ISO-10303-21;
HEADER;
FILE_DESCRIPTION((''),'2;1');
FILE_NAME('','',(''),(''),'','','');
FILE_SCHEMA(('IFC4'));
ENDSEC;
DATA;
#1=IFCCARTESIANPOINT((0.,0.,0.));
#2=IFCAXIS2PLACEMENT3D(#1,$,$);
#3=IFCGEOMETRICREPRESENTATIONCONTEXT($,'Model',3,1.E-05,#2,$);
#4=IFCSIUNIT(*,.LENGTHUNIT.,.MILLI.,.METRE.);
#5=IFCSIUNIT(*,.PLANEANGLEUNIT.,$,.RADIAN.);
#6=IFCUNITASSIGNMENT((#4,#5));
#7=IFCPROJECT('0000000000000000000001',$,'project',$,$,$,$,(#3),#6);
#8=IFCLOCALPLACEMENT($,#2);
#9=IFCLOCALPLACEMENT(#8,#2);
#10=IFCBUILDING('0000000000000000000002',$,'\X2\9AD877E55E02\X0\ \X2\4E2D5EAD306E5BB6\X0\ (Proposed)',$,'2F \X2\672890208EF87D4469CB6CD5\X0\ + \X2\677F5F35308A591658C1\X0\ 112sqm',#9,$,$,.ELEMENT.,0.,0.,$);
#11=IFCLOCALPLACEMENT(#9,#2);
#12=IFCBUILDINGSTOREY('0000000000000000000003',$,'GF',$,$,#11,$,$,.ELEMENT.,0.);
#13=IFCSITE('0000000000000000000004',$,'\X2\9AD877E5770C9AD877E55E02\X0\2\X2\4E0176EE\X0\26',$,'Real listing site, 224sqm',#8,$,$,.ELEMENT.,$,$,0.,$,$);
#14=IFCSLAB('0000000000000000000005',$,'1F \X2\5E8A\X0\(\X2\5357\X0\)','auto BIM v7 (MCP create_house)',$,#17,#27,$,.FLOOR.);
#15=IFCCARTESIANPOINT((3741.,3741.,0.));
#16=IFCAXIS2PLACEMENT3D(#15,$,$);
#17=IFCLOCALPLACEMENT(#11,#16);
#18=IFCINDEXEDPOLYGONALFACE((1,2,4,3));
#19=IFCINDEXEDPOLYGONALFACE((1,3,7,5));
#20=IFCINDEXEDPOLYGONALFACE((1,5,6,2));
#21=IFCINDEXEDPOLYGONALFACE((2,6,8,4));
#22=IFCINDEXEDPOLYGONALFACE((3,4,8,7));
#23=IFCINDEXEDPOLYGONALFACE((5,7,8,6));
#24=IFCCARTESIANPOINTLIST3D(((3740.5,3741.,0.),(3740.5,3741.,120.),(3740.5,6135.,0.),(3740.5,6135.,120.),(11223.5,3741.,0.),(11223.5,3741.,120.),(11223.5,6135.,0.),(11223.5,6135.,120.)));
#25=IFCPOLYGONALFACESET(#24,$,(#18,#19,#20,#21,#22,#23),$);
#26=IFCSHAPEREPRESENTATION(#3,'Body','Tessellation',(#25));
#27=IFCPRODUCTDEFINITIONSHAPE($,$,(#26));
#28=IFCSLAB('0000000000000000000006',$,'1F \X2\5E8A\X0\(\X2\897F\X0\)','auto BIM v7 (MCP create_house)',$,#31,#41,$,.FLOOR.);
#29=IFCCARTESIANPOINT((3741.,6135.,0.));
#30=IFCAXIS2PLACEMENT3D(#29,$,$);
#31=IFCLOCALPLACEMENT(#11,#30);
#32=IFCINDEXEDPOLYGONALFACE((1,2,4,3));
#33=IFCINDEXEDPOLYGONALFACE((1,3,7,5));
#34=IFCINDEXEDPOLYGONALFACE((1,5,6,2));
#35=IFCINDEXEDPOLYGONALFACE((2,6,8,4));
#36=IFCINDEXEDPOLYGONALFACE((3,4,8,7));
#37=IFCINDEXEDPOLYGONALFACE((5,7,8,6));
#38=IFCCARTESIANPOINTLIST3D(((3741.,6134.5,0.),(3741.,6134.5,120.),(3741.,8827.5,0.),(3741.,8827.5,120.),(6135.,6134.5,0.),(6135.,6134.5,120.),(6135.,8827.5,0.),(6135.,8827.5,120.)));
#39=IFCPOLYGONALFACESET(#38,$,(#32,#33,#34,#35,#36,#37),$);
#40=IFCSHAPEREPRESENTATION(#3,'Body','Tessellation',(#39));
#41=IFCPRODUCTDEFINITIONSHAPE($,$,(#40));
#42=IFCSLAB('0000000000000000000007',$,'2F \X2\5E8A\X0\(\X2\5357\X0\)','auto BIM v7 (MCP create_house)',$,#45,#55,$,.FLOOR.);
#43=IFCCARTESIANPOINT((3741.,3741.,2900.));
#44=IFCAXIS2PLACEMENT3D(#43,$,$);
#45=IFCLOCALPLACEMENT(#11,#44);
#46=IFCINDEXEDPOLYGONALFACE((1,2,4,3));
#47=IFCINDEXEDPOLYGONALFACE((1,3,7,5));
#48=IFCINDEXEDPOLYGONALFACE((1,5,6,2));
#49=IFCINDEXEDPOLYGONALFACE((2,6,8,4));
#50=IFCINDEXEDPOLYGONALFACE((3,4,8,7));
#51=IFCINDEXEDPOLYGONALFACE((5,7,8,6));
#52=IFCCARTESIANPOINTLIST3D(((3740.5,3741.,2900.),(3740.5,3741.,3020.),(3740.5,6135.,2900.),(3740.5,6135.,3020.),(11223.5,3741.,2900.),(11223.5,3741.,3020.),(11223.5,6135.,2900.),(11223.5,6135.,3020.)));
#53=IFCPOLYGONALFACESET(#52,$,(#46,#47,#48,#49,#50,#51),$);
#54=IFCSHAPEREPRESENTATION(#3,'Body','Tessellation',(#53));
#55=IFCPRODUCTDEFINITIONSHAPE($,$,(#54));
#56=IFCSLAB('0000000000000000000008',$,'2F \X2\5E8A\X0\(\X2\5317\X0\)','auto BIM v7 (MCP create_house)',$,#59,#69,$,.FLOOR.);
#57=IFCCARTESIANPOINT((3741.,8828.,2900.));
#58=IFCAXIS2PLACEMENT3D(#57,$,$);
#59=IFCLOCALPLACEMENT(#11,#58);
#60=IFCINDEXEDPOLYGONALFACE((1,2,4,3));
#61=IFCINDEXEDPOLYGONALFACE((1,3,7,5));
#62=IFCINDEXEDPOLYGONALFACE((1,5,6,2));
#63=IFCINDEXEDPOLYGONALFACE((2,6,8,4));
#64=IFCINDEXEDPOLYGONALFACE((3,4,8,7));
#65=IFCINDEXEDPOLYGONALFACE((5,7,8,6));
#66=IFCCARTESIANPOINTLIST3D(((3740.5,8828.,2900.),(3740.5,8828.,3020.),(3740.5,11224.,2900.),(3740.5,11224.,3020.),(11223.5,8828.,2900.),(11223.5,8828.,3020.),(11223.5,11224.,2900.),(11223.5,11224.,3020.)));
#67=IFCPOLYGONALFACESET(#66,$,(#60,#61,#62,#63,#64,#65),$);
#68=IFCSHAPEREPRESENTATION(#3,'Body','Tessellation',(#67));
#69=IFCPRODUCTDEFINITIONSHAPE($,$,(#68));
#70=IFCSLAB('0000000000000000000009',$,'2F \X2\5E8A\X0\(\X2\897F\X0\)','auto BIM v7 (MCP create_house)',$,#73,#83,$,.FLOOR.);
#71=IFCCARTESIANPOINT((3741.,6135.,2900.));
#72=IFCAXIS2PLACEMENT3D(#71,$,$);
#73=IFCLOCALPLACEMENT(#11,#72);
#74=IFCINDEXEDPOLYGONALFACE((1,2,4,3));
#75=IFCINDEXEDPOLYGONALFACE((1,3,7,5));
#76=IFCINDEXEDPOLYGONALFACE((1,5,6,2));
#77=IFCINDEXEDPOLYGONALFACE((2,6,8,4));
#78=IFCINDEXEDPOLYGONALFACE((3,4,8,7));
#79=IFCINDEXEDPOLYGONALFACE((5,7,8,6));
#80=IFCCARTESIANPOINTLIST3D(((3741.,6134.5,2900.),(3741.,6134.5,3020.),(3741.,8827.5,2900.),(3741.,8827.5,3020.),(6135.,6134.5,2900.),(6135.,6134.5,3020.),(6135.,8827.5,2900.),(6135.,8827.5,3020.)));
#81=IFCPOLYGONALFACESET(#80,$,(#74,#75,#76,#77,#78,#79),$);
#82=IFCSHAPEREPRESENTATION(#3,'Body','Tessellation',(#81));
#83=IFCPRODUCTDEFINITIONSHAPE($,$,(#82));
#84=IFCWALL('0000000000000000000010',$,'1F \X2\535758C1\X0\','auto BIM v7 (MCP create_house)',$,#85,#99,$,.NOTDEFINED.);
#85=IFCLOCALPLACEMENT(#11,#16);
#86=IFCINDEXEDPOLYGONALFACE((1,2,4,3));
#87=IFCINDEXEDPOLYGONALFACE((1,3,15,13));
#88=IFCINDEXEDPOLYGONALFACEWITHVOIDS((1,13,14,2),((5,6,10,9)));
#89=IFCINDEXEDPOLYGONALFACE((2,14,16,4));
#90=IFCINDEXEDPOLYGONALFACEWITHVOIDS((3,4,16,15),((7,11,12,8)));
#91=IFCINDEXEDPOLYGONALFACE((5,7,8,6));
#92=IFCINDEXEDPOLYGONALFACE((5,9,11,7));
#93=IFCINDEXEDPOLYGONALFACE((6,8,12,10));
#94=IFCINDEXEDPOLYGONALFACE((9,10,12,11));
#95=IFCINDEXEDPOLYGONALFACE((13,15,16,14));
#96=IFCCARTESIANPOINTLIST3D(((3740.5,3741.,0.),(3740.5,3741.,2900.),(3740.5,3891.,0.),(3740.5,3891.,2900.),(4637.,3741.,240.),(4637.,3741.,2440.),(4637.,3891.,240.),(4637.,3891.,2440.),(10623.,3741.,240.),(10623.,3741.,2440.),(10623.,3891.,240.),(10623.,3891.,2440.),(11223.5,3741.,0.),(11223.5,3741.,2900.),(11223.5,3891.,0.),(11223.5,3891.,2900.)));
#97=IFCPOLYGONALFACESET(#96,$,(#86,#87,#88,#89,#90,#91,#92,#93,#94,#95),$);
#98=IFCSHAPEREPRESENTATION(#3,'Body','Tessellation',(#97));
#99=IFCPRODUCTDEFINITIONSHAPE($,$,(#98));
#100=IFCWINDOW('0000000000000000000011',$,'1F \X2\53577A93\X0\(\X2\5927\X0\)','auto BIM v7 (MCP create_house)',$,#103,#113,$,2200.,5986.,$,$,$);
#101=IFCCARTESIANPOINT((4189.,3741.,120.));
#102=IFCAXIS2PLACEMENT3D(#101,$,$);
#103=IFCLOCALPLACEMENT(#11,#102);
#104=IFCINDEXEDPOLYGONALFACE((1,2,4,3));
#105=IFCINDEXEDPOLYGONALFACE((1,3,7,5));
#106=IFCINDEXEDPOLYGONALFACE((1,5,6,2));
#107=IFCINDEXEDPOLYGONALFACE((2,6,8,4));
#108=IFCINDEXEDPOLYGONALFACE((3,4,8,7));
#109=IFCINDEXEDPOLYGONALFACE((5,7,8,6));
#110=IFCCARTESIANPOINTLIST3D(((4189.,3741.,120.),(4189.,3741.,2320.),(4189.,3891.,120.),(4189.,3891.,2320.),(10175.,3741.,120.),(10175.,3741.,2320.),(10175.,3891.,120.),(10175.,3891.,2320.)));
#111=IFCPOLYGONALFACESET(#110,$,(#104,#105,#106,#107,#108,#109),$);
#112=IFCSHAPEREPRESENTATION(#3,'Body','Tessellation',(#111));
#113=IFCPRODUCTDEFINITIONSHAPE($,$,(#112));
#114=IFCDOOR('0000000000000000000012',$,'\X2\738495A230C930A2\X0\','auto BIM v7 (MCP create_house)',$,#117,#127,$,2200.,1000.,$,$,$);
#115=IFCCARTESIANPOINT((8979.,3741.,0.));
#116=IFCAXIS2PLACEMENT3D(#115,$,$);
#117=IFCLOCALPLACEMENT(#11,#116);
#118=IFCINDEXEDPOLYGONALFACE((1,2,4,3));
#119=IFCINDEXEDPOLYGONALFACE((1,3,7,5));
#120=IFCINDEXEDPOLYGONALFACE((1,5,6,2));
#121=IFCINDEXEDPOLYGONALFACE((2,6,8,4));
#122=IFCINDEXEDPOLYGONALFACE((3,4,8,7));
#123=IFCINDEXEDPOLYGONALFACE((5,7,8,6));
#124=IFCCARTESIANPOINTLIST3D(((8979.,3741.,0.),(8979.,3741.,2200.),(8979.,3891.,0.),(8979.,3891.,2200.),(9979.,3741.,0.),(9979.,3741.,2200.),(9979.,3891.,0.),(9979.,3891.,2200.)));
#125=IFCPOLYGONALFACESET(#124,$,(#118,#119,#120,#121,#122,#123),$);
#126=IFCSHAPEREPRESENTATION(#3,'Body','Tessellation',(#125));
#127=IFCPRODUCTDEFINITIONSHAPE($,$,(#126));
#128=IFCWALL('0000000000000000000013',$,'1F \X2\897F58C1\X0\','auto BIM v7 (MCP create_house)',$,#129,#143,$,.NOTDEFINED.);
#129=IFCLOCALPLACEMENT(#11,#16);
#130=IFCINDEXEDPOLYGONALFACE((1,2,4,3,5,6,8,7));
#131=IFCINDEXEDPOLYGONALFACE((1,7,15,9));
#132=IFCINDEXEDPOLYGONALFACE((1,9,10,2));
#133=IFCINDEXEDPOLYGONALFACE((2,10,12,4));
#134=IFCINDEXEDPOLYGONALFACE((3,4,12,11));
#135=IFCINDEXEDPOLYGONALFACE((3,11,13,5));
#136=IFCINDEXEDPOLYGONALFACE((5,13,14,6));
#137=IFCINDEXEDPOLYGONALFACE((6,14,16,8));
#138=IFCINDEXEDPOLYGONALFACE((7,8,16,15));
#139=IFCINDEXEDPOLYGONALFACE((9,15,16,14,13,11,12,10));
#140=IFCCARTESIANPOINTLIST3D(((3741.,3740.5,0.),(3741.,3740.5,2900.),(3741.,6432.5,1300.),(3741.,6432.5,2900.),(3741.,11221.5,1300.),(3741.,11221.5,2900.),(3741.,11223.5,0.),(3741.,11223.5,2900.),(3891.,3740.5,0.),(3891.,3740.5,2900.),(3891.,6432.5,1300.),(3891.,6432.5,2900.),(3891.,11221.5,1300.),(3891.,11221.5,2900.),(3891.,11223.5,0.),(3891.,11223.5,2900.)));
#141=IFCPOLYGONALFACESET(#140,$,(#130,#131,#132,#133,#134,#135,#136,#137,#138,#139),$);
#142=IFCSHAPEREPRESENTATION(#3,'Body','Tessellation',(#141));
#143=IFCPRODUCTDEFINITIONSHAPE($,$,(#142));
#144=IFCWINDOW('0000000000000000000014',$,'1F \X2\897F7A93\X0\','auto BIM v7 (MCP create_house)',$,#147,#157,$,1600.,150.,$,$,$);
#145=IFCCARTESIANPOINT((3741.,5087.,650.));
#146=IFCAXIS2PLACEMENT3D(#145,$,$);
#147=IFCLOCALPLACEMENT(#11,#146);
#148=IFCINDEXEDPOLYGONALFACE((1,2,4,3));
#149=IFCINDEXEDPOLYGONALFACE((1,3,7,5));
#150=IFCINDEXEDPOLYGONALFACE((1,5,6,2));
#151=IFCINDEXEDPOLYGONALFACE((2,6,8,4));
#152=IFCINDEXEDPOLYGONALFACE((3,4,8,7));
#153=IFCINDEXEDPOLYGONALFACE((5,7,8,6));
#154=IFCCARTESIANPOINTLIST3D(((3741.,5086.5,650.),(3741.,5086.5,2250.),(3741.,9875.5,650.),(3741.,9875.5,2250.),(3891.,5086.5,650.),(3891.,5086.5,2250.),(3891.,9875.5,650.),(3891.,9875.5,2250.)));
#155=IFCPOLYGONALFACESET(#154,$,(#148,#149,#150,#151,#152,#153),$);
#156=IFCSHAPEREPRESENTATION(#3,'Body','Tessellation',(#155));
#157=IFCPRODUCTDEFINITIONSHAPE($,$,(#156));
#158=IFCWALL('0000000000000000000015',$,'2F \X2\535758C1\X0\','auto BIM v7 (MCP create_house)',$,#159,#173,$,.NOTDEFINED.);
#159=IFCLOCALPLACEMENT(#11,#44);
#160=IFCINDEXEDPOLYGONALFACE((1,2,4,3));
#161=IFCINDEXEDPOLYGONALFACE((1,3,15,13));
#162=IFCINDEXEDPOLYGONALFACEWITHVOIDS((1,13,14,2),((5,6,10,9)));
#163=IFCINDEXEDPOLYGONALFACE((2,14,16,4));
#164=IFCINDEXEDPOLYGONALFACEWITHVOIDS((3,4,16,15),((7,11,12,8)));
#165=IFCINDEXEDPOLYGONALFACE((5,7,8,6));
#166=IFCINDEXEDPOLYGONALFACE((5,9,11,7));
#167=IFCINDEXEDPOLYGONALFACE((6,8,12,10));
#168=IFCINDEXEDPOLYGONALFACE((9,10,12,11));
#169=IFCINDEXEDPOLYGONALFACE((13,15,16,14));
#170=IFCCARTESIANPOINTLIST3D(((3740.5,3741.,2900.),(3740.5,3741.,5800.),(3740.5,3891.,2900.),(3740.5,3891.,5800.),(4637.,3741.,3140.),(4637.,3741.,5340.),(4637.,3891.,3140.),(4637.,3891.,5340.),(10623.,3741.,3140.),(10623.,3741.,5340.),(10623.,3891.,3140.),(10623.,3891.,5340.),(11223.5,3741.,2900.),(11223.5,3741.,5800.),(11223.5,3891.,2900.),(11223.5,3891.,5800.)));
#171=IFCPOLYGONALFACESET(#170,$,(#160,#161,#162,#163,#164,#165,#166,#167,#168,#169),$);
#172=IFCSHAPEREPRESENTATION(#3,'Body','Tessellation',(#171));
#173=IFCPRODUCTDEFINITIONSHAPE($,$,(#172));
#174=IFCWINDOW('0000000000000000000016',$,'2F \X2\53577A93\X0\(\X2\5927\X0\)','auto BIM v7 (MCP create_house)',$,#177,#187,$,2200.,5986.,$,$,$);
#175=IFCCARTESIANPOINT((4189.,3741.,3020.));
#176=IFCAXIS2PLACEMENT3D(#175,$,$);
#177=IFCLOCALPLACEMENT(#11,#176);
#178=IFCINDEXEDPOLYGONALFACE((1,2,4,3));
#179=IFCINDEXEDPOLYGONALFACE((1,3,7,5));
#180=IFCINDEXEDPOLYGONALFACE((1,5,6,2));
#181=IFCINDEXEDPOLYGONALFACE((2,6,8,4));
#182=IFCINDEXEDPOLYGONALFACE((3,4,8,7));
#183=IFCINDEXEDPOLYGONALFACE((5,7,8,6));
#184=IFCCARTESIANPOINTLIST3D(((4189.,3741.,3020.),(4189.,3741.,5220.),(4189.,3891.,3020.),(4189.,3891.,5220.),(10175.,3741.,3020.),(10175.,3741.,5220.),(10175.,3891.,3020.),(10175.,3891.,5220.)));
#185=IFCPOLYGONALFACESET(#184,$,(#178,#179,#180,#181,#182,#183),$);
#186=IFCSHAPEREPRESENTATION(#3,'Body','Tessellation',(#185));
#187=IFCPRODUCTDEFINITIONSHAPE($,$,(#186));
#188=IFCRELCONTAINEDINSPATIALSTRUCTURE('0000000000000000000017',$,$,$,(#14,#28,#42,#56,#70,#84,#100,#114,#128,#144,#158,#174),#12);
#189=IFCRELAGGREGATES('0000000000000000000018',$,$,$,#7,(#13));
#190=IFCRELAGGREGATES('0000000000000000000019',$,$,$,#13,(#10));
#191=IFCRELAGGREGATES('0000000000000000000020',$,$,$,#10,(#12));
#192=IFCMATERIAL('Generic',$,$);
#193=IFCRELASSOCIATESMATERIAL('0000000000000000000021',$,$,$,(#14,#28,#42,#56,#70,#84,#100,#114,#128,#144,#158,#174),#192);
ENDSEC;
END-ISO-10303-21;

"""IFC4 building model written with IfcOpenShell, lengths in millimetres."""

from ifc_helpers import new_model, si_unit, frame, frame_2d, origin, place, context, project, spatial, rectangle, extrude, material, element, fill, save


model = new_model("IFC4")

# Units and contexts
model_context = context("Model", 3, precision=1e-05, world=origin())
ifc_project = project(units=[si_unit("LENGTHUNIT", "METRE", prefix="MILLI"), si_unit("PLANEANGLEUNIT", "RADIAN")], contexts=[model_context])

# Site, building, storey
site_placement = place(None, origin())
site = spatial("IfcSite", under=ifc_project, at=site_placement, Name="高知県高知市2丁目26", ObjectType="Real listing site, 224sqm", CompositionType="ELEMENT", RefElevation=0.0)
building_placement = place(site_placement, origin())
building = spatial("IfcBuilding", under=site, at=building_placement, Name="高知市 中庭の家 (Proposed)", ObjectType="2F 木造軸組構法 + 板張り外壁 112sqm", CompositionType="ELEMENT", ElevationOfRefHeight=0.0, ElevationOfTerrain=0.0)
storey_placement = place(building_placement, origin())
storey = spatial("IfcBuildingStorey", under=building, at=storey_placement, Name="GF", CompositionType="ELEMENT", Elevation=0.0)

# Slabs
ifc_material = material(Name="Generic")
slab_1_placement = place(storey_placement, frame((3741.0, 3741.0, 0.0)))
element("IfcSlab", 1, at=slab_1_placement, inside=storey, material=ifc_material, Name="1F 床(南)", Description="auto BIM v7 (MCP create_house)", PredefinedType="FLOOR", context=model_context, shape_type="SweptSolid", body=[
    extrude(rectangle(XDim=7483.0, YDim=2394.0, at=frame_2d((3741.0, 1197.0))), frame((3741.0, 3741.0, 0.0)), (0.0, 0.0, 1.0), 120.0),
])
slab_2_placement = place(storey_placement, frame((3741.0, 6135.0, 0.0)))
element("IfcSlab", 2, at=slab_2_placement, inside=storey, material=ifc_material, Name="1F 床(西)", Description="auto BIM v7 (MCP create_house)", PredefinedType="FLOOR", context=model_context, shape_type="SweptSolid", body=[
    extrude(rectangle(XDim=2394.0, YDim=2693.0, at=frame_2d((1197.0, 1346.0))), frame((3741.0, 6135.0, 0.0)), (0.0, 0.0, 1.0), 120.0),
])
slab_3_placement = place(storey_placement, frame((3741.0, 3741.0, 2900.0)))
element("IfcSlab", 3, at=slab_3_placement, inside=storey, material=ifc_material, Name="2F 床(南)", Description="auto BIM v7 (MCP create_house)", PredefinedType="FLOOR", context=model_context, shape_type="SweptSolid", body=[
    extrude(rectangle(XDim=7483.0, YDim=2394.0, at=frame_2d((3741.0, 1197.0))), frame((3741.0, 3741.0, 2900.0)), (0.0, 0.0, 1.0), 120.0),
])
slab_4_placement = place(storey_placement, frame((3741.0, 8828.0, 2900.0)))
element("IfcSlab", 4, at=slab_4_placement, inside=storey, material=ifc_material, Name="2F 床(北)", Description="auto BIM v7 (MCP create_house)", PredefinedType="FLOOR", context=model_context, shape_type="SweptSolid", body=[
    extrude(rectangle(XDim=7483.0, YDim=2396.0, at=frame_2d((3741.0, 1198.0))), frame((3741.0, 8828.0, 2900.0)), (0.0, 0.0, 1.0), 120.0),
])
slab_5_placement = place(storey_placement, frame((3741.0, 6135.0, 2900.0)))
element("IfcSlab", 5, at=slab_5_placement, inside=storey, material=ifc_material, Name="2F 床(西)", Description="auto BIM v7 (MCP create_house)", PredefinedType="FLOOR", context=model_context, shape_type="SweptSolid", body=[
    extrude(rectangle(XDim=2394.0, YDim=2693.0, at=frame_2d((1197.0, 1346.0))), frame((3741.0, 6135.0, 2900.0)), (0.0, 0.0, 1.0), 120.0),
])

# Wall, openings, window, door
wall_1_placement = place(storey_placement, frame((3741.0, 3741.0, 0.0)))
wall_1 = element("IfcWall", 6, at=wall_1_placement, inside=storey, material=ifc_material, Name="1F 南壁", Description="auto BIM v7 (MCP create_house)", PredefinedType="NOTDEFINED", context=model_context, shape_type="SweptSolid", body=[
    extrude(rectangle(XDim=7483.0, YDim=150.0, at=frame_2d((3741.0, 75.0))), frame((3741.0, 3741.0, 0.0)), (0.0, 0.0, 1.0), 2900.0),
])
opening_1_placement = place(storey_placement, frame((4189.0, 3741.0, 120.0)))
opening_1 = element("IfcOpeningElement", 7, at=opening_1_placement, cuts=wall_1, PredefinedType="NOTDEFINED", context=model_context, shape_type="SweptSolid", body=[
    extrude(rectangle(XDim=5986.0, YDim=150.0, at=frame_2d((2993.0, 75.0))), frame((4189.0, 3741.0, 120.0)), (0.0, 0.0, 1.0), 2200.0),
])
opening_2_placement = place(storey_placement, frame((8979.0, 3741.0, 0.0)))
opening_2 = element("IfcOpeningElement", 8, at=opening_2_placement, cuts=wall_1, PredefinedType="NOTDEFINED", context=model_context, shape_type="SweptSolid", body=[
    extrude(rectangle(XDim=1000.0, YDim=150.0, at=frame_2d((500.0, 75.0))), frame((8979.0, 3741.0, 0.0)), (0.0, 0.0, 1.0), 2200.0),
])
window_1_placement = place(storey_placement, frame((4189.0, 3741.0, 120.0)))
window_1 = element("IfcWindow", 9, at=window_1_placement, inside=storey, material=ifc_material, Name="1F 南窓(大)", Description="auto BIM v7 (MCP create_house)", OverallHeight=2200.0, OverallWidth=5986.0, context=model_context, shape_type="SweptSolid", body=[
    extrude(rectangle(XDim=5986.0, YDim=150.0, at=frame_2d((2993.0, 75.0))), frame((4189.0, 3741.0, 120.0)), (0.0, 0.0, 1.0), 2200.0),
])
fill(opening_1, window_1)
door_placement = place(storey_placement, frame((8979.0, 3741.0, 0.0)))
door = element("IfcDoor", 10, at=door_placement, inside=storey, material=ifc_material, Name="玄関ドア", Description="auto BIM v7 (MCP create_house)", OverallHeight=2200.0, OverallWidth=1000.0, context=model_context, shape_type="SweptSolid", body=[
    extrude(rectangle(XDim=1000.0, YDim=150.0, at=frame_2d((500.0, 75.0))), frame((8979.0, 3741.0, 0.0)), (0.0, 0.0, 1.0), 2200.0),
])
fill(opening_2, door)

# Walls, openings, windows
wall_2_placement = place(storey_placement, frame((3741.0, 3741.0, 0.0)))
wall_2 = element("IfcWall", 11, at=wall_2_placement, inside=storey, material=ifc_material, Name="1F 西壁", Description="auto BIM v7 (MCP create_house)", PredefinedType="NOTDEFINED", context=model_context, shape_type="SweptSolid", body=[
    extrude(rectangle(XDim=150.0, YDim=7483.0, at=frame_2d((75.0, 3741.0))), frame((3741.0, 3741.0, 0.0)), (0.0, 0.0, 1.0), 2900.0),
])
opening_3_placement = place(storey_placement, frame((3741.0, 5087.0, 650.0)))
opening_3 = element("IfcOpeningElement", 12, at=opening_3_placement, cuts=wall_2, PredefinedType="NOTDEFINED", context=model_context, shape_type="SweptSolid", body=[
    extrude(rectangle(XDim=150.0, YDim=4789.0, at=frame_2d((75.0, 2394.0))), frame((3741.0, 5087.0, 650.0)), (0.0, 0.0, 1.0), 1600.0),
])
window_2_placement = place(storey_placement, frame((3741.0, 5087.0, 650.0)))
window_2 = element("IfcWindow", 13, at=window_2_placement, inside=storey, material=ifc_material, Name="1F 西窓", Description="auto BIM v7 (MCP create_house)", OverallHeight=1600.0, OverallWidth=150.0, context=model_context, shape_type="SweptSolid", body=[
    extrude(rectangle(XDim=150.0, YDim=4789.0, at=frame_2d((75.0, 2394.0))), frame((3741.0, 5087.0, 650.0)), (0.0, 0.0, 1.0), 1600.0),
])
fill(opening_3, window_2)
wall_3_placement = place(storey_placement, frame((3741.0, 3741.0, 2900.0)))
wall_3 = element("IfcWall", 14, at=wall_3_placement, inside=storey, material=ifc_material, Name="2F 南壁", Description="auto BIM v7 (MCP create_house)", PredefinedType="NOTDEFINED", context=model_context, shape_type="SweptSolid", body=[
    extrude(rectangle(XDim=7483.0, YDim=150.0, at=frame_2d((3741.0, 75.0))), frame((3741.0, 3741.0, 2900.0)), (0.0, 0.0, 1.0), 2900.0),
])
opening_4_placement = place(storey_placement, frame((4189.0, 3741.0, 3020.0)))
opening_4 = element("IfcOpeningElement", 15, at=opening_4_placement, cuts=wall_3, PredefinedType="NOTDEFINED", context=model_context, shape_type="SweptSolid", body=[
    extrude(rectangle(XDim=5986.0, YDim=150.0, at=frame_2d((2993.0, 75.0))), frame((4189.0, 3741.0, 3020.0)), (0.0, 0.0, 1.0), 2200.0),
])
window_3_placement = place(storey_placement, frame((4189.0, 3741.0, 3020.0)))
window_3 = element("IfcWindow", 16, at=window_3_placement, inside=storey, material=ifc_material, Name="2F 南窓(大)", Description="auto BIM v7 (MCP create_house)", OverallHeight=2200.0, OverallWidth=5986.0, context=model_context, shape_type="SweptSolid", body=[
    extrude(rectangle(XDim=5986.0, YDim=150.0, at=frame_2d((2993.0, 75.0))), frame((4189.0, 3741.0, 3020.0)), (0.0, 0.0, 1.0), 2200.0),
])
fill(opening_4, window_3)

save(model, "model.ifc")
